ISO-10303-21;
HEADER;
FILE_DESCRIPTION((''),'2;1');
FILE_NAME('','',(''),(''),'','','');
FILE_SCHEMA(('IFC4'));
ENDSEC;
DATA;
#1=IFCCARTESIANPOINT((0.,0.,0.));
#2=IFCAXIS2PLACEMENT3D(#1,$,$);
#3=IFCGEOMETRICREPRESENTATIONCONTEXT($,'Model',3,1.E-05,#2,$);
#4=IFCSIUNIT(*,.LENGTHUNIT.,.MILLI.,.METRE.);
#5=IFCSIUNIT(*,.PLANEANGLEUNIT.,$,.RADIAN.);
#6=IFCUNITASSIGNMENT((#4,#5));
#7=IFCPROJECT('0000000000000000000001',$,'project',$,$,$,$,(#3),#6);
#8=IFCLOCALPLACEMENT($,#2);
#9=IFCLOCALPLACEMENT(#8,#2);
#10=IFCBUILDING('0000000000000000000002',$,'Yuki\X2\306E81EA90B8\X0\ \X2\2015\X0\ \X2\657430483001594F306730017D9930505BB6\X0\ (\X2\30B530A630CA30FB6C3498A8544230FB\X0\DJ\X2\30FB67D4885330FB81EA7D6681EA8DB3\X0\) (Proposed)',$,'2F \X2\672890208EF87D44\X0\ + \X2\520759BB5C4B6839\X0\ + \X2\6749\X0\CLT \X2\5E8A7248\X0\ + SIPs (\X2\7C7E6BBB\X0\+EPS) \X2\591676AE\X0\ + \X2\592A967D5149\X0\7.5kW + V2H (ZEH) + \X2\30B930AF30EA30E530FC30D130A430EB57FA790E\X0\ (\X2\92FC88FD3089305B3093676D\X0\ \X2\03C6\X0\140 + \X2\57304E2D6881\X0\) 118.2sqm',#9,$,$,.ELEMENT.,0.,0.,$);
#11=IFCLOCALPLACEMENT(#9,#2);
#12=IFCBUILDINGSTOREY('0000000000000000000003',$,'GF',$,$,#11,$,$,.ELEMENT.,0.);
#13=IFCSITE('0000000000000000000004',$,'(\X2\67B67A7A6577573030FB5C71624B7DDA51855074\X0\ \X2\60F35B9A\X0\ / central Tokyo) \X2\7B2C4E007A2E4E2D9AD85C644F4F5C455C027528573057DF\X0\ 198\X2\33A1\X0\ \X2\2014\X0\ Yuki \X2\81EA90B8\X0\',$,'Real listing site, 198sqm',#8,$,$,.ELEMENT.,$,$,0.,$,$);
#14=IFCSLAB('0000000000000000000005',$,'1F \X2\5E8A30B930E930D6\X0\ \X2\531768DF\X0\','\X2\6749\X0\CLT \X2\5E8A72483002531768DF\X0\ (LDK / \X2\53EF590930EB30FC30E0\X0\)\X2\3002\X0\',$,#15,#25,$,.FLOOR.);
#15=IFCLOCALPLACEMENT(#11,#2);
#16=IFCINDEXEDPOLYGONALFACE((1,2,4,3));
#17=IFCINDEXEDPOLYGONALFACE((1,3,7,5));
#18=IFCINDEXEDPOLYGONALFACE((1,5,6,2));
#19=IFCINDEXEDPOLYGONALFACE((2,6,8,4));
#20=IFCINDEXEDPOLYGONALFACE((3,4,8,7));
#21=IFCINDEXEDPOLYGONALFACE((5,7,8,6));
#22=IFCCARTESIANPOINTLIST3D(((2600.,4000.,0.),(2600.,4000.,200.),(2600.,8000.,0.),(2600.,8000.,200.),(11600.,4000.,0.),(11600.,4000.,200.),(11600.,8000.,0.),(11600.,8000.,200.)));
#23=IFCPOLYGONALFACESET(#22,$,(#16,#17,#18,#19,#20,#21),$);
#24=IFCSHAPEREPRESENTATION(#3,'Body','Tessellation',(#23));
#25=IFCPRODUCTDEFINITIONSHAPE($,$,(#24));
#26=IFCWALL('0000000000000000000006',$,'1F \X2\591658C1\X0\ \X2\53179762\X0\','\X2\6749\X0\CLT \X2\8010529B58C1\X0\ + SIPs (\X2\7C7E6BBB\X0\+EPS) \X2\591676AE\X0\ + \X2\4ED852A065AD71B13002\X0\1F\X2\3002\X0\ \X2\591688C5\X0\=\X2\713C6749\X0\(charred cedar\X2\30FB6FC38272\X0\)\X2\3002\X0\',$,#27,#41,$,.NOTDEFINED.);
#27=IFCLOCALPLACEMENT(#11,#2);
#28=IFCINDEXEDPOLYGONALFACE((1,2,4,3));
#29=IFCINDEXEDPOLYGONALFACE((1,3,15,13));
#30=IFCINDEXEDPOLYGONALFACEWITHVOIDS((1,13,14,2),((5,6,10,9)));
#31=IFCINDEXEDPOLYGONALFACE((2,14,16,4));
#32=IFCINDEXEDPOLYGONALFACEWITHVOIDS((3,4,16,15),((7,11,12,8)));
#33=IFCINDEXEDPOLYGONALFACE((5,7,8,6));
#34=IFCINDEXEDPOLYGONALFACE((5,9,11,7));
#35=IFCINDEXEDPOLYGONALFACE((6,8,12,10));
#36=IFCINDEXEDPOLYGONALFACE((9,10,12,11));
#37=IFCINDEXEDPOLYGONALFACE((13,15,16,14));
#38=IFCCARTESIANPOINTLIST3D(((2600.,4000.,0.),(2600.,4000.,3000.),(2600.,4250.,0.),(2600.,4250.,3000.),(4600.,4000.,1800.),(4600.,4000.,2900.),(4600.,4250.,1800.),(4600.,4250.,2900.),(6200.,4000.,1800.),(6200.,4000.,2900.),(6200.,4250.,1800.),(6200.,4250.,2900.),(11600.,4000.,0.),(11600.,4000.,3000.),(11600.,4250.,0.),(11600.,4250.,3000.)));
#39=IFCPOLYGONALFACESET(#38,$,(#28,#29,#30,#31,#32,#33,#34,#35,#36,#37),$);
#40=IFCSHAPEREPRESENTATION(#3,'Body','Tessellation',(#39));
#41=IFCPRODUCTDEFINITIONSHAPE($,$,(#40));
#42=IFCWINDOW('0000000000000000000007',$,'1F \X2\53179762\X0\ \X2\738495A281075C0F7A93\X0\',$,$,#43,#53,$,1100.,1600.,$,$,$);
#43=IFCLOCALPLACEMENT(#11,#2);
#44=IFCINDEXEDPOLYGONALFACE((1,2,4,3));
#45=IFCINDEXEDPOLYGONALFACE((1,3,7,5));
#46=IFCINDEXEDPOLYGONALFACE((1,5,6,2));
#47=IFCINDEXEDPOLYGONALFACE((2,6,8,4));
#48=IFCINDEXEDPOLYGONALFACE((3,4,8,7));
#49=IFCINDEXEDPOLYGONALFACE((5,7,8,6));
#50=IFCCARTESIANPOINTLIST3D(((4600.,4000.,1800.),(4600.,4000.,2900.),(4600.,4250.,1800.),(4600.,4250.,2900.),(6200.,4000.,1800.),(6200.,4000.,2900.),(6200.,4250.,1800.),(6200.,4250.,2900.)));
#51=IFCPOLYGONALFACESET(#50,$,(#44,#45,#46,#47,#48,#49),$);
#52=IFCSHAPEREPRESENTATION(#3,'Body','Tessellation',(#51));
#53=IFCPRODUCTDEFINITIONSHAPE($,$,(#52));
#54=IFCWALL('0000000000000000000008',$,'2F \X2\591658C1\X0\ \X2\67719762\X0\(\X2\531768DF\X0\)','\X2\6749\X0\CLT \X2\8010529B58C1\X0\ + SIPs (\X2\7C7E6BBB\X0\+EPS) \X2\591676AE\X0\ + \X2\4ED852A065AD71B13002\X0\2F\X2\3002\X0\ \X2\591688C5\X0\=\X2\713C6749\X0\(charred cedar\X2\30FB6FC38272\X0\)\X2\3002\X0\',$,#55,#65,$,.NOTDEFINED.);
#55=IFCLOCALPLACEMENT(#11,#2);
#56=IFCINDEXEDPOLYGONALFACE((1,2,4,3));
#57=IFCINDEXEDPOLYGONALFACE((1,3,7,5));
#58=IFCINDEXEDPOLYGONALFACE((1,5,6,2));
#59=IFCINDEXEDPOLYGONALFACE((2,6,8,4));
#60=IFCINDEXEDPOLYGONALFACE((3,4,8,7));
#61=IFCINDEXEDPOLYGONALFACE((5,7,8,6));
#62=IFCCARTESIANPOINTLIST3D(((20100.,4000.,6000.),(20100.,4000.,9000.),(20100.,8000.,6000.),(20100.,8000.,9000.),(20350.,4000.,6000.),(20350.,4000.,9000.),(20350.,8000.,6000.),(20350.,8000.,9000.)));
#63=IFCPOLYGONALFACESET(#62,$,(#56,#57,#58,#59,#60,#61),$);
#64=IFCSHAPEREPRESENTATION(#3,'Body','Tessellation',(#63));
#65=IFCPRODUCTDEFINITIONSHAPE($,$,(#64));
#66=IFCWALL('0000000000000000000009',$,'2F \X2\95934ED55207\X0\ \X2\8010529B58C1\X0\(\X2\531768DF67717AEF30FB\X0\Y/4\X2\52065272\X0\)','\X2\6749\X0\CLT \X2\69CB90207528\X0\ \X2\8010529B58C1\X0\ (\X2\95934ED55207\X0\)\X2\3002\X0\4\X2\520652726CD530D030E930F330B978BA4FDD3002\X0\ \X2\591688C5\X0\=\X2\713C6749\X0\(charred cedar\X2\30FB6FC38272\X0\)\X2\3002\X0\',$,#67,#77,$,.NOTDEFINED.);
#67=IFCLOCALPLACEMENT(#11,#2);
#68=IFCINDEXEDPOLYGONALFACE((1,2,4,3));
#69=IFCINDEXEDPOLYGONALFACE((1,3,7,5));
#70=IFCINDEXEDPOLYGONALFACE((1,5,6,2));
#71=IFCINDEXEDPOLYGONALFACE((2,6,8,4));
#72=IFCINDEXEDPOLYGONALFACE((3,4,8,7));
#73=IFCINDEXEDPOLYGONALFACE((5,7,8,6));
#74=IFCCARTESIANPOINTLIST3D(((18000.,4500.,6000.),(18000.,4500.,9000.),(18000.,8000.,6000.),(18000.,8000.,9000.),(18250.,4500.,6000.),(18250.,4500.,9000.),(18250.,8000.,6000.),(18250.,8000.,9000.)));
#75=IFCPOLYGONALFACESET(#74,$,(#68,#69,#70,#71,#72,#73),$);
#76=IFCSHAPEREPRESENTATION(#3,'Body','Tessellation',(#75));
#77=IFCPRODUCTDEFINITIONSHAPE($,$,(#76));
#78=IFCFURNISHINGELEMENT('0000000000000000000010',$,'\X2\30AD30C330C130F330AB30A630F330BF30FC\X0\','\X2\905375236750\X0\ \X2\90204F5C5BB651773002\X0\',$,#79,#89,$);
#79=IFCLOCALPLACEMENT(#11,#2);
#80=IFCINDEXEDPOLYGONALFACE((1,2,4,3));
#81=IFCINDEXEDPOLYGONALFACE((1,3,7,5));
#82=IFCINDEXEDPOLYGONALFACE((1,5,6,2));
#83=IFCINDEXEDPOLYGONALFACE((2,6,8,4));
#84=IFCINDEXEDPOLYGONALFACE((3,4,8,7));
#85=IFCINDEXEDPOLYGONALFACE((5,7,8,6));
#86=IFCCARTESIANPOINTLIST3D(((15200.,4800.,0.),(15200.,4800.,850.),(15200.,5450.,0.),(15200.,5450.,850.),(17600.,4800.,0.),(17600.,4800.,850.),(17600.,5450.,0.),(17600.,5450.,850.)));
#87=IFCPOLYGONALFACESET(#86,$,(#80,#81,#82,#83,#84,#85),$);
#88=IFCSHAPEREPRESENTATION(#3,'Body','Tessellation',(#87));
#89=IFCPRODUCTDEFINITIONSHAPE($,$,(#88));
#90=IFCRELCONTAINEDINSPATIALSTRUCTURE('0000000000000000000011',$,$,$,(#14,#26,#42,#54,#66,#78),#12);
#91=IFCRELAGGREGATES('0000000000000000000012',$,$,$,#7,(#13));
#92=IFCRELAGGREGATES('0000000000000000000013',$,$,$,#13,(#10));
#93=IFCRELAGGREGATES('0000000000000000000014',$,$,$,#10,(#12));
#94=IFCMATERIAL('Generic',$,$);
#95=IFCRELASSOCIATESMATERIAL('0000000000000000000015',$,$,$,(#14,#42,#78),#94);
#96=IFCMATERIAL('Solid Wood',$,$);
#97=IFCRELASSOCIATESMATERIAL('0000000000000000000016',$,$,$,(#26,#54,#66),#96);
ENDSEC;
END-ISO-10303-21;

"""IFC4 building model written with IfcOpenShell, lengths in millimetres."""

from ifc_helpers import new_model, si_unit, frame, frame_2d, origin, place, context, project, spatial, rectangle, extrude, material, element, fill, save


model = new_model("IFC4")

# Units and contexts
model_context = context("Model", 3, precision=1e-05, world=origin())
ifc_project = project(units=[si_unit("LENGTHUNIT", "METRE", prefix="MILLI"), si_unit("PLANEANGLEUNIT", "RADIAN")], contexts=[model_context])

# Site, building, storey
site_placement = place(None, origin())
site = spatial("IfcSite", under=ifc_project, at=site_placement, Name="(架空敷地・山手線内側 想定 / central Tokyo) 第一種中高層住居専用地域 198㎡ — Yuki 自邸", ObjectType="Real listing site, 198sqm", CompositionType="ELEMENT", RefElevation=0.0)
building_placement = place(site_placement, origin())
building = spatial("IfcBuilding", under=site, at=building_placement, Name="Yukiの自邸 ― 整え、奏で、継ぐ家 (サウナ・水風呂・DJ・柔術・自給自足) (Proposed)", ObjectType="2F 木造軸組 + 切妻屋根 + 杉CLT 床版 + SIPs (籾殻+EPS) 外皮 + 太陽光7.5kW + V2H (ZEH) + スクリューパイル基礎 (鋼製らせん杭 φ140 + 地中梁) 118.2sqm", CompositionType="ELEMENT", ElevationOfRefHeight=0.0, ElevationOfTerrain=0.0)
storey_placement = place(building_placement, origin())
storey = spatial("IfcBuildingStorey", under=building, at=storey_placement, Name="GF", CompositionType="ELEMENT", Elevation=0.0)

# Shared definitions
ifc_material_1 = material(Name="Generic")

# Slab
slab_1_placement = place(storey_placement, frame((1300.0, 2000.0, 0.0)))
element("IfcSlab", 1, at=slab_1_placement, inside=storey, material=ifc_material_1, Name="1F 床スラブ 北棟", Description="杉CLT 床版。北棟 (LDK / 可変ルーム)。", PredefinedType="FLOOR", context=model_context, shape_type="SweptSolid", body=[
    extrude(rectangle(XDim=9000.0, YDim=4000.0, at=frame_2d((4500.0, 2000.0))), frame((1300.0, 2000.0, 0.0)), (0.0, 0.0, 1.0), 200.0),
])

# Wall, opening, window
ifc_material_2 = material(Name="Solid Wood")
wall_1_placement = place(storey_placement, frame((1300.0, 2000.0, 0.0)))
wall_1 = element("IfcWall", 2, at=wall_1_placement, inside=storey, material=ifc_material_2, Name="1F 外壁 北面", Description="杉CLT 耐力壁 + SIPs (籾殻+EPS) 外皮 + 付加断熱。1F。 外装=焼杉(charred cedar・濃色)。", PredefinedType="NOTDEFINED", context=model_context, shape_type="SweptSolid", body=[
    extrude(rectangle(XDim=9000.0, YDim=250.0, at=frame_2d((4500.0, 125.0))), frame((1300.0, 2000.0, 0.0)), (0.0, 0.0, 1.0), 3000.0),
])
opening_1_placement = place(storey_placement, frame((2300.0, 2000.0, 900.0)))
opening_1 = element("IfcOpeningElement", 3, at=opening_1_placement, cuts=wall_1, PredefinedType="NOTDEFINED", context=model_context, shape_type="SweptSolid", body=[
    extrude(rectangle(XDim=1600.0, YDim=250.0, at=frame_2d((800.0, 125.0))), frame((2300.0, 2000.0, 900.0)), (0.0, 0.0, 1.0), 1100.0),
])
window_1_placement = place(storey_placement, frame((2300.0, 2000.0, 900.0)))
window_1 = element("IfcWindow", 4, at=window_1_placement, inside=storey, material=ifc_material_1, Name="1F 北面 玄関脇小窓", OverallHeight=1100.0, OverallWidth=1600.0, context=model_context, shape_type="SweptSolid", body=[
    extrude(rectangle(XDim=1600.0, YDim=250.0, at=frame_2d((800.0, 125.0))), frame((2300.0, 2000.0, 900.0)), (0.0, 0.0, 1.0), 1100.0),
])
fill(opening_1, window_1)

# Wall
wall_2_placement = place(storey_placement, frame((10050.0, 2000.0, 3000.0)))
element("IfcWall", 5, at=wall_2_placement, inside=storey, material=ifc_material_2, Name="2F 外壁 東面(北棟)", Description="杉CLT 耐力壁 + SIPs (籾殻+EPS) 外皮 + 付加断熱。2F。 外装=焼杉(charred cedar・濃色)。", PredefinedType="NOTDEFINED", context=model_context, shape_type="SweptSolid", body=[
    extrude(rectangle(XDim=250.0, YDim=4000.0, at=frame_2d((125.0, 2000.0))), frame((10050.0, 2000.0, 3000.0)), (0.0, 0.0, 1.0), 3000.0),
])

# Wall
wall_3_placement = place(storey_placement, frame((9000.0, 2250.0, 3000.0)))
element("IfcWall", 6, at=wall_3_placement, inside=storey, material=ifc_material_2, Name="2F 間仕切 耐力壁(北棟東端・Y/4分割)", Description="杉CLT 構造用 耐力壁 (間仕切)。4分割法バランス確保。 外装=焼杉(charred cedar・濃色)。", PredefinedType="NOTDEFINED", context=model_context, shape_type="SweptSolid", body=[
    extrude(rectangle(XDim=250.0, YDim=3500.0, at=frame_2d((125.0, 1750.0))), frame((9000.0, 2250.0, 3000.0)), (0.0, 0.0, 1.0), 3000.0),
])

# Furnishing element
furnishing_1_placement = place(storey_placement, frame((7600.0, 2400.0, 0.0)))
element("IfcFurnishingElement", 7, at=furnishing_1_placement, inside=storey, material=ifc_material_1, Name="キッチンカウンター", Description="道産材 造作家具。", context=model_context, shape_type="SweptSolid", body=[
    extrude(rectangle(XDim=2400.0, YDim=650.0, at=frame_2d((1200.0, 325.0))), frame((7600.0, 2400.0, 0.0)), (0.0, 0.0, 1.0), 850.0),
])

save(model, "model.ifc")
